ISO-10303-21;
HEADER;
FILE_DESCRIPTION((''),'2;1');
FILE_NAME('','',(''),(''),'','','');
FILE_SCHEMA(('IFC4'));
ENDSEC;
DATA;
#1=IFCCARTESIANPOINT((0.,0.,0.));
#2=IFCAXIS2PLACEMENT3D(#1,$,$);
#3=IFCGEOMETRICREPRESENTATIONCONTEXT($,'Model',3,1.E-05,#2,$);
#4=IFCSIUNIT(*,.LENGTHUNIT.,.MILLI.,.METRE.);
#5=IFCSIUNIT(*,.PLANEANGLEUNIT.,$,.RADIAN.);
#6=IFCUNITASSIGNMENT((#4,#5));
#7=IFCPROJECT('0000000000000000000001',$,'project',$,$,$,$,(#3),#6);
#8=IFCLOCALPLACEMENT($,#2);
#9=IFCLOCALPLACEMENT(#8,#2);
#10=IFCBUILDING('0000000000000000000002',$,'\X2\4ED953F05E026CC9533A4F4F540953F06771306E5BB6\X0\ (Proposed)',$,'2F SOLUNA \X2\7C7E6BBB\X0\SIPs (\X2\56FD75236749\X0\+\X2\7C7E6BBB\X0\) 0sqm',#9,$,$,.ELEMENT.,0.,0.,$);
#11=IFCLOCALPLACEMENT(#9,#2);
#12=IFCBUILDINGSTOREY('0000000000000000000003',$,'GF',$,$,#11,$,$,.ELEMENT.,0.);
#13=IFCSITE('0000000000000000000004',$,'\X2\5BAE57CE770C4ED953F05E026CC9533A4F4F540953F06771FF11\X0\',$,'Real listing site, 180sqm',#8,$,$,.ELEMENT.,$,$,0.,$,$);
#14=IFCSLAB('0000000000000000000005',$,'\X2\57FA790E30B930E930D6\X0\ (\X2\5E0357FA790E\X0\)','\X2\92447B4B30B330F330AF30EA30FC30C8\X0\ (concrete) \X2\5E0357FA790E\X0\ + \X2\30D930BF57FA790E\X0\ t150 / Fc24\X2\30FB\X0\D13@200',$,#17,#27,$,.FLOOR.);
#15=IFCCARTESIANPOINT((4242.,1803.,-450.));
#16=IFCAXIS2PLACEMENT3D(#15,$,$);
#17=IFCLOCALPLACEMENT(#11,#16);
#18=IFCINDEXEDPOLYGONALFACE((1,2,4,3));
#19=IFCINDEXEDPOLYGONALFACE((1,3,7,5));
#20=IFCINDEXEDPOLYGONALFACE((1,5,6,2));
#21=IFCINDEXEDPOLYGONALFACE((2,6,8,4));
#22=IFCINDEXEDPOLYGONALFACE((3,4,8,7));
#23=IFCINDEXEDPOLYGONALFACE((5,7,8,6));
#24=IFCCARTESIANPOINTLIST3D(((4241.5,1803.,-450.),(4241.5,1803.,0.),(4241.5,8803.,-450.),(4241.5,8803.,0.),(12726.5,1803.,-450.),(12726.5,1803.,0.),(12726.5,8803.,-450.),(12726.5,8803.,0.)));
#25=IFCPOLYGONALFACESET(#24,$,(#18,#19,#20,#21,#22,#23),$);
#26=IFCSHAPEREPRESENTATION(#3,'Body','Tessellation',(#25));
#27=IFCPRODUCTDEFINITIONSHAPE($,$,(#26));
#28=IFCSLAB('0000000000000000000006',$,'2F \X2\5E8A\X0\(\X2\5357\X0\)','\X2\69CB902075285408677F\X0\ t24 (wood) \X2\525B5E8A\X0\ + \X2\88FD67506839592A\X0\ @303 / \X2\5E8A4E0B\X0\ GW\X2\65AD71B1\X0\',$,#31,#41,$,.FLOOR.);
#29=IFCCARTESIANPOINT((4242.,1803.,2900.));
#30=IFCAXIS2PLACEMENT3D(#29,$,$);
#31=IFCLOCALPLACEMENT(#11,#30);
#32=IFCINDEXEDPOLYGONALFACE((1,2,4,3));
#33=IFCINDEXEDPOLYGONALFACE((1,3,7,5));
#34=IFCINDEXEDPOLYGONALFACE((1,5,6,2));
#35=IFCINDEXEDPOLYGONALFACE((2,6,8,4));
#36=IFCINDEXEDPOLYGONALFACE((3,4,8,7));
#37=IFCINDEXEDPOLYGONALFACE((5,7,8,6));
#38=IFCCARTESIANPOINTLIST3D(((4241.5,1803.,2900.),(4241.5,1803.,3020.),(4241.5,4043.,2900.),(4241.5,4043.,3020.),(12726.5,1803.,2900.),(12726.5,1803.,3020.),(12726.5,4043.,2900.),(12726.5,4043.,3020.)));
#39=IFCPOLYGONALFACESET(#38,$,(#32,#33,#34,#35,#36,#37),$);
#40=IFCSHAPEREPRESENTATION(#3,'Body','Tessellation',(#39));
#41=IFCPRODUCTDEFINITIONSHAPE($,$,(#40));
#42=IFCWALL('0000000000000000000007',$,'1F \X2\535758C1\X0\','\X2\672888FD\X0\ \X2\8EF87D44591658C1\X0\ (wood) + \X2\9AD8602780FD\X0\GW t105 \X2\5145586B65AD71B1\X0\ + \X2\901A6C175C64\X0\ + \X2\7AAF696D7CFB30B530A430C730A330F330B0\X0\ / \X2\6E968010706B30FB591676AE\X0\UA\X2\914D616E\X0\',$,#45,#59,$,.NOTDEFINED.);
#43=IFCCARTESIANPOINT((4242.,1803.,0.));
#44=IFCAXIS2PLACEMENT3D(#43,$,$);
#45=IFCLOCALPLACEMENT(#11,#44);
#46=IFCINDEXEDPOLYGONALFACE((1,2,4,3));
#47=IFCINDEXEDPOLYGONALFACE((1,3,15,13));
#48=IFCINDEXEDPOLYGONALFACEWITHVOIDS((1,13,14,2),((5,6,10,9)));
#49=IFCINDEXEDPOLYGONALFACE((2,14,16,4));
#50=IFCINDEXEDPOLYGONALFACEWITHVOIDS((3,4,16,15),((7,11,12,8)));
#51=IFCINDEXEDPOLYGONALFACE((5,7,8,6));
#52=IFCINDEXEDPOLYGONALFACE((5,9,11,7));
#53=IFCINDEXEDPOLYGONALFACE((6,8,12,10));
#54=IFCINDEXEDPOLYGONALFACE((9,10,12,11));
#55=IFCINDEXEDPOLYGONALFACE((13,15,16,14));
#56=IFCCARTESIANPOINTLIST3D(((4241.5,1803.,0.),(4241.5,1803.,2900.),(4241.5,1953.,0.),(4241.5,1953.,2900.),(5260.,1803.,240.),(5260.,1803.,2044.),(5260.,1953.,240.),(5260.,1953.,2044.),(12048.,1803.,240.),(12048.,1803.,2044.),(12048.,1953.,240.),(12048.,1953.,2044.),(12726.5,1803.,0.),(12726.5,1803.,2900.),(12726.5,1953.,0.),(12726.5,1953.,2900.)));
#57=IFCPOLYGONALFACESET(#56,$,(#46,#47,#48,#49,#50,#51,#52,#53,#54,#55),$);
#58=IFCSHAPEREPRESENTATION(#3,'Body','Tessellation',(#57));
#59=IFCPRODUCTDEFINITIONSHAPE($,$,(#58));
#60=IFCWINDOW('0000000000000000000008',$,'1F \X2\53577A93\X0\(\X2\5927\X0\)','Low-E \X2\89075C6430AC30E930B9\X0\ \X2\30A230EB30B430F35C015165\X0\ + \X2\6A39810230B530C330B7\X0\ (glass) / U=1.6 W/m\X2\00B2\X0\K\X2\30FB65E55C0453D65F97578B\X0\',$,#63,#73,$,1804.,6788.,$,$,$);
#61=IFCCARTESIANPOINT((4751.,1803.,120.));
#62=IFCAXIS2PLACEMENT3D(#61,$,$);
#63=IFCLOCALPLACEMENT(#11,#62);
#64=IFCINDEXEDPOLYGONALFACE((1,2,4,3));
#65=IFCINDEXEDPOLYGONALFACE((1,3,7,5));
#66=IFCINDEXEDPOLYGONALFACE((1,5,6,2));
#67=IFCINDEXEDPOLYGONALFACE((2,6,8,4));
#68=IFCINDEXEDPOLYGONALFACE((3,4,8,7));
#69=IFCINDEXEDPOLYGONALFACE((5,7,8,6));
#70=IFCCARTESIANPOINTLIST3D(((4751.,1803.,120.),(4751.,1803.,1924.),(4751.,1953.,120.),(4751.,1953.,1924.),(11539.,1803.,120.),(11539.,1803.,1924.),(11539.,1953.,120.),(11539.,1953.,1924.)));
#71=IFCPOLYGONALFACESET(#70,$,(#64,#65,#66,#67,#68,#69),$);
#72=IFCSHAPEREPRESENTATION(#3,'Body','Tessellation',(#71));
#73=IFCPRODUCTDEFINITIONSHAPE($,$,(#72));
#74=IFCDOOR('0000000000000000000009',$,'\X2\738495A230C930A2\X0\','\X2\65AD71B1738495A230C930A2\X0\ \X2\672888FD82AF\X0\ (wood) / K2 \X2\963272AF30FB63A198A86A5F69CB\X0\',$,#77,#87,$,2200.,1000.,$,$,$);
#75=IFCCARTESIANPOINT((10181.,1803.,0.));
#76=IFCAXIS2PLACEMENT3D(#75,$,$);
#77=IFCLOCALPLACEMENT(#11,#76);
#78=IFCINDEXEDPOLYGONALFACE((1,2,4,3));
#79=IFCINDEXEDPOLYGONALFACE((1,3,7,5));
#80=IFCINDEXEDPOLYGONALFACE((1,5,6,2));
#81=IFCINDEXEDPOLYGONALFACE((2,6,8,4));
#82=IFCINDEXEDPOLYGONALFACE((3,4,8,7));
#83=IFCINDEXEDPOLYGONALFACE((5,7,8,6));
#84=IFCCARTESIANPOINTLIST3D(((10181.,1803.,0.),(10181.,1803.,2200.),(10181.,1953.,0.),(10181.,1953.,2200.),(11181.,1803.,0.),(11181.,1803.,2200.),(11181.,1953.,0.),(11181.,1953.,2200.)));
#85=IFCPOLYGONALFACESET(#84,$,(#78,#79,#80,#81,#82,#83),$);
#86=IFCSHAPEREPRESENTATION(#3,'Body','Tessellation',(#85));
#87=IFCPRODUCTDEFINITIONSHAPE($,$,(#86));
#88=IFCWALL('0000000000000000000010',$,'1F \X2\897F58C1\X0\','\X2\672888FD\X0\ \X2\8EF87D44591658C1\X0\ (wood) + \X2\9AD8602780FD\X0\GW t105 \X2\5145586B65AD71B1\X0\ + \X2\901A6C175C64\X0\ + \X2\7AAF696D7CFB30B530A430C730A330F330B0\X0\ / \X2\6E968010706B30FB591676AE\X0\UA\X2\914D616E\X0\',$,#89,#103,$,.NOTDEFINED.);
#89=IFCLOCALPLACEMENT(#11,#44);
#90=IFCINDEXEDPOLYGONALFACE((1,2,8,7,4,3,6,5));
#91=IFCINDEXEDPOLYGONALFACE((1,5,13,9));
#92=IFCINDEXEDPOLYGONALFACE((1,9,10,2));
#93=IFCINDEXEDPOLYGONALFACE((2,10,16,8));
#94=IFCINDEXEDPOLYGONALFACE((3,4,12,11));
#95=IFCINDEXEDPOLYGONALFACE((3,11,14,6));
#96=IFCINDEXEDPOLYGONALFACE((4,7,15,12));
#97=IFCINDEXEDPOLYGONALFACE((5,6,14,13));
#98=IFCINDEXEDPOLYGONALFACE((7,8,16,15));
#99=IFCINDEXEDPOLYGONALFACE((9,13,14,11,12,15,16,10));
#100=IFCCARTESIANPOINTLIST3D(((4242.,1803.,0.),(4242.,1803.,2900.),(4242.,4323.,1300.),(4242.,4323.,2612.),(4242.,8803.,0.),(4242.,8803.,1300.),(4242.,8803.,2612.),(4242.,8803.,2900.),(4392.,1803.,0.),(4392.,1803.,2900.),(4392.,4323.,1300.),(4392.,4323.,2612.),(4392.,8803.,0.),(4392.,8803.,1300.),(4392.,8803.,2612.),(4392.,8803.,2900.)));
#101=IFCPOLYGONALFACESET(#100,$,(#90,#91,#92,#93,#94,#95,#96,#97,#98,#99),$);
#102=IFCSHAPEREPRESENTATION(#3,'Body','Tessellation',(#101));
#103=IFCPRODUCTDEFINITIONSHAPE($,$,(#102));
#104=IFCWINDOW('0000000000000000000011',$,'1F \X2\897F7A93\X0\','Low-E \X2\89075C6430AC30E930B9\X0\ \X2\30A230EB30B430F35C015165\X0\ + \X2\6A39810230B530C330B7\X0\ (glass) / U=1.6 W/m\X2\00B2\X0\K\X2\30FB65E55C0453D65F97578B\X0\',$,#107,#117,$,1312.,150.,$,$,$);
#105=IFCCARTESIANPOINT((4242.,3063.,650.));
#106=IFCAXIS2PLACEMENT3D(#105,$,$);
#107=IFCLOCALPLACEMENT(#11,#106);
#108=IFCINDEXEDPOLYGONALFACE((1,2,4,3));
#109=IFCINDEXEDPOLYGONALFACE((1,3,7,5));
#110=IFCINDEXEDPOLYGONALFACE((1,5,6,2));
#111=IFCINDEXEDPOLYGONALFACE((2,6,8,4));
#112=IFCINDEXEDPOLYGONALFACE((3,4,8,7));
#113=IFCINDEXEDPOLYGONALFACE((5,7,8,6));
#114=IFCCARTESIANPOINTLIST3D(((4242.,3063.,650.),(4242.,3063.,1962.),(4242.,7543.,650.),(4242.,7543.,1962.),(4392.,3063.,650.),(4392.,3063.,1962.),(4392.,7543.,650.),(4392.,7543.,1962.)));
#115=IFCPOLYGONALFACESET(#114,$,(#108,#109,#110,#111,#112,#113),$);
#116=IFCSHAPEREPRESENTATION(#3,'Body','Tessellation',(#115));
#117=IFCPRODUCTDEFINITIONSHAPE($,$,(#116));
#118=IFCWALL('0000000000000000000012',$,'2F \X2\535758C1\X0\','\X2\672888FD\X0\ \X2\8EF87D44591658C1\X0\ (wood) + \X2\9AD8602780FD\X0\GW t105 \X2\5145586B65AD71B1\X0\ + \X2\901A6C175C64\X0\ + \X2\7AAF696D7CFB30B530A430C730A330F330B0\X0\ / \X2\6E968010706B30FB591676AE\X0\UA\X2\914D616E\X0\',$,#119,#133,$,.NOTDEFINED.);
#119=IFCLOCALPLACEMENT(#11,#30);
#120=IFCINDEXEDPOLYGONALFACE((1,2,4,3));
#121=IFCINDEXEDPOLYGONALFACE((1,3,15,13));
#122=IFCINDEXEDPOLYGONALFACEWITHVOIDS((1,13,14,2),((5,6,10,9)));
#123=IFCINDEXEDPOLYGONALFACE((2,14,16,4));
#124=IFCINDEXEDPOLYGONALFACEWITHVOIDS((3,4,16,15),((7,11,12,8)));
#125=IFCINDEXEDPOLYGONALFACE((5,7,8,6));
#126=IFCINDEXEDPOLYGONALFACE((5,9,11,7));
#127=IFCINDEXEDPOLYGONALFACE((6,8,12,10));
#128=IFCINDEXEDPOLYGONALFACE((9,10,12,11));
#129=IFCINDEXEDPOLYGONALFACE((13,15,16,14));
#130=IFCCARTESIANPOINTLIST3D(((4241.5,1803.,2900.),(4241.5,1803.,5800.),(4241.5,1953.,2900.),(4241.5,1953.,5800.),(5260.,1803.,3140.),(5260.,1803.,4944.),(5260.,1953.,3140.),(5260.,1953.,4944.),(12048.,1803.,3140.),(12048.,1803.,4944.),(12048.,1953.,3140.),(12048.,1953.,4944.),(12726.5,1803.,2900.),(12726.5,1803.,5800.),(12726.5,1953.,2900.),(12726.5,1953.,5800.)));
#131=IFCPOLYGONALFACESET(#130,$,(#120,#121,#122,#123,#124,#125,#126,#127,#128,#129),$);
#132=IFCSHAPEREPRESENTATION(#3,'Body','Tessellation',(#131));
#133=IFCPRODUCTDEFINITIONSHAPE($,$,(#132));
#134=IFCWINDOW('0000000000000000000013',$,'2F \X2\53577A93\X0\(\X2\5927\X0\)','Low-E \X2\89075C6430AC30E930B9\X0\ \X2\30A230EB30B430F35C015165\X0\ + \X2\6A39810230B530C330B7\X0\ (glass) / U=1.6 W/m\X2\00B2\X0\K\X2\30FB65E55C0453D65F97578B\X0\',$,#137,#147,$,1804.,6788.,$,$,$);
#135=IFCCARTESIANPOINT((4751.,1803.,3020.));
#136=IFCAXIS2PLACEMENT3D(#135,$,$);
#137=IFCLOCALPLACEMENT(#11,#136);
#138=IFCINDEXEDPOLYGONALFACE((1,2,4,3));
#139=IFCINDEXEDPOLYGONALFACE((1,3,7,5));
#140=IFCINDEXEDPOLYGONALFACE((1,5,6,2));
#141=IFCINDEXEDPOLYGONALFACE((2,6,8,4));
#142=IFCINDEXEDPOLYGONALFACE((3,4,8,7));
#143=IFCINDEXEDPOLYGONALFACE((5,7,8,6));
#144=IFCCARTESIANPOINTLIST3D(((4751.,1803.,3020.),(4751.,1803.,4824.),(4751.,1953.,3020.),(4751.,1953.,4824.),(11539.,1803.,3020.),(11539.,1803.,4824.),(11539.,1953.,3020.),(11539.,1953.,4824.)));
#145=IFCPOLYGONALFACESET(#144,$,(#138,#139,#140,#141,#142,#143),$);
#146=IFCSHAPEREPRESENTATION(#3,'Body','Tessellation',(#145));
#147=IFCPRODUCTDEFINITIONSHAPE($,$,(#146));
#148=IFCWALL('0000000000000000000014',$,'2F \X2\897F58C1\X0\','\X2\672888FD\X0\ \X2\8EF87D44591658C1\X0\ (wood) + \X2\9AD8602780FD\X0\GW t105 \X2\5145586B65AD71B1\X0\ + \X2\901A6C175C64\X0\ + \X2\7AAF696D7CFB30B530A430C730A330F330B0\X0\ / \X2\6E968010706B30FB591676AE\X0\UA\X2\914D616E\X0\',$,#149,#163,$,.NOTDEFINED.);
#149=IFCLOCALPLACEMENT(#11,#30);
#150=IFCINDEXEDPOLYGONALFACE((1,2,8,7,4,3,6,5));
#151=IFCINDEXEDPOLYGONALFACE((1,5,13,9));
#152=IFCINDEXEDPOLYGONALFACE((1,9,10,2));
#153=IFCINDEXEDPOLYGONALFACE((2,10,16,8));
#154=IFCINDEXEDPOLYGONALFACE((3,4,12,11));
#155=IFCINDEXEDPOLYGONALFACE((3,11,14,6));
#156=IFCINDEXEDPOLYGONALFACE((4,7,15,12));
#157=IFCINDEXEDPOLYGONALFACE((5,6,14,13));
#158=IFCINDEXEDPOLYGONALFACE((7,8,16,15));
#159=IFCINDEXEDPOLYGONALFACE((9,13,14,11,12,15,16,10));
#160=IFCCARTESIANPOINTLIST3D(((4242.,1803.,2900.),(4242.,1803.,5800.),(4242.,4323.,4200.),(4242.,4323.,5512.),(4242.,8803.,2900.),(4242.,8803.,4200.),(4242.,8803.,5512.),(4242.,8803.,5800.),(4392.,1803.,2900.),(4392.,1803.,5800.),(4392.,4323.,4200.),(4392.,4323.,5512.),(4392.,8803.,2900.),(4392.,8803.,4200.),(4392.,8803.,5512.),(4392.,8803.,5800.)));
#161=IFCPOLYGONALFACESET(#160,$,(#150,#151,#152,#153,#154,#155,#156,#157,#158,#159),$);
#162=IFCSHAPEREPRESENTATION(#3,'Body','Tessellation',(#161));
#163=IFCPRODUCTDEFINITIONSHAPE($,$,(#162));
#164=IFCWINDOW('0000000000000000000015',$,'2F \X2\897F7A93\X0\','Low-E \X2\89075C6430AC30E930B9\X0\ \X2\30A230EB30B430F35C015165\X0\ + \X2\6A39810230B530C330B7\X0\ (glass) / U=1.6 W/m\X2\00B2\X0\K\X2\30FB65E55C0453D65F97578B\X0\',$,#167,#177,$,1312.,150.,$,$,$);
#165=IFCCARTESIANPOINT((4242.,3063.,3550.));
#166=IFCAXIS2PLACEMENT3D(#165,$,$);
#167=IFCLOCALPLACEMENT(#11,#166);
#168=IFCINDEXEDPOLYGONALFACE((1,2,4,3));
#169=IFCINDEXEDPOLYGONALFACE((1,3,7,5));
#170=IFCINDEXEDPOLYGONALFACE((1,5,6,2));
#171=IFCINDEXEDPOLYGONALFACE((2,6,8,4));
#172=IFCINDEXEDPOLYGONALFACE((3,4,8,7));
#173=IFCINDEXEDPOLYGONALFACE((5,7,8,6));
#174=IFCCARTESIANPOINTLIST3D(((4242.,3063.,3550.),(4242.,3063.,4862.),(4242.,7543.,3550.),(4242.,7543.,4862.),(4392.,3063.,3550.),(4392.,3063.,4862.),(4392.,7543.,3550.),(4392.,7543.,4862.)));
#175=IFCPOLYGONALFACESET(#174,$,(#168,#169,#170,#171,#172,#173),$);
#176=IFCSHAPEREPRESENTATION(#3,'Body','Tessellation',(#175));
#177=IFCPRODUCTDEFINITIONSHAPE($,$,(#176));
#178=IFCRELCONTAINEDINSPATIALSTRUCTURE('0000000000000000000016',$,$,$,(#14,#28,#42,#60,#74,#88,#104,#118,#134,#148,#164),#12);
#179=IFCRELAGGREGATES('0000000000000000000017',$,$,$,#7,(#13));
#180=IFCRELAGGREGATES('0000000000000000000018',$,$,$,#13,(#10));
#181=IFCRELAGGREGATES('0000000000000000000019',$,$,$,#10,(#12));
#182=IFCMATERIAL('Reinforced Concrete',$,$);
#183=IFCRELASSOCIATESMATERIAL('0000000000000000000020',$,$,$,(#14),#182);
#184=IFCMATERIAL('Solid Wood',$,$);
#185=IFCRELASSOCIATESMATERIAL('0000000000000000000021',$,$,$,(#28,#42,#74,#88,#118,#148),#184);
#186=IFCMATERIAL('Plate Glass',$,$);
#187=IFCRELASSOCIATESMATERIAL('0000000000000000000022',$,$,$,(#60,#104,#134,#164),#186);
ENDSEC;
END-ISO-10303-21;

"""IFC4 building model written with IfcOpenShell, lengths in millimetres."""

from ifc_helpers import new_model, si_unit, frame, frame_2d, origin, place, context, project, spatial, rectangle, extrude, material, element, fill, save


model = new_model("IFC4")

# Units and contexts
model_context = context("Model", 3, precision=1e-05, world=origin())
ifc_project = project(units=[si_unit("LENGTHUNIT", "METRE", prefix="MILLI"), si_unit("PLANEANGLEUNIT", "RADIAN")], contexts=[model_context])

# Site, building, storey
site_placement = place(None, origin())
site = spatial("IfcSite", under=ifc_project, at=site_placement, Name="宮城県仙台市泉区住吉台東１", ObjectType="Real listing site, 180sqm", CompositionType="ELEMENT", RefElevation=0.0)
building_placement = place(site_placement, origin())
building = spatial("IfcBuilding", under=site, at=building_placement, Name="仙台市泉区住吉台東の家 (Proposed)", ObjectType="2F SOLUNA 籾殻SIPs (国産杉+籾殻) 0sqm", CompositionType="ELEMENT", ElevationOfRefHeight=0.0, ElevationOfTerrain=0.0)
storey_placement = place(building_placement, origin())
storey = spatial("IfcBuildingStorey", under=building, at=storey_placement, Name="GF", CompositionType="ELEMENT", Elevation=0.0)

# Slabs
ifc_material_1 = material(Name="Reinforced Concrete")
slab_1_placement = place(storey_placement, frame((4242.0, 1803.0, -450.0)))
element("IfcSlab", 1, at=slab_1_placement, inside=storey, material=ifc_material_1, Name="基礎スラブ (布基礎)", Description="鉄筋コンクリート (concrete) 布基礎 + ベタ基礎 t150 / Fc24・D13@200", PredefinedType="FLOOR", context=model_context, shape_type="SweptSolid", body=[
    extrude(rectangle(XDim=8485.0, YDim=7000.0, at=frame_2d((4242.0, 3500.0))), frame((4242.0, 1803.0, -450.0)), (0.0, 0.0, 1.0), 450.0),
])
ifc_material_2 = material(Name="Solid Wood")
slab_2_placement = place(storey_placement, frame((4242.0, 1803.0, 2900.0)))
element("IfcSlab", 2, at=slab_2_placement, inside=storey, material=ifc_material_2, Name="2F 床(南)", Description="構造用合板 t24 (wood) 剛床 + 製材根太 @303 / 床下 GW断熱", PredefinedType="FLOOR", context=model_context, shape_type="SweptSolid", body=[
    extrude(rectangle(XDim=8485.0, YDim=2240.0, at=frame_2d((4242.0, 1120.0))), frame((4242.0, 1803.0, 2900.0)), (0.0, 0.0, 1.0), 120.0),
])

# Wall, openings, window, door
wall_1_placement = place(storey_placement, frame((4242.0, 1803.0, 0.0)))
wall_1 = element("IfcWall", 3, at=wall_1_placement, inside=storey, material=ifc_material_2, Name="1F 南壁", Description="木製 軸組外壁 (wood) + 高性能GW t105 充填断熱 + 通気層 + 窯業系サイディング / 準耐火・外皮UA配慮", PredefinedType="NOTDEFINED", context=model_context, shape_type="SweptSolid", body=[
    extrude(rectangle(XDim=8485.0, YDim=150.0, at=frame_2d((4242.0, 75.0))), frame((4242.0, 1803.0, 0.0)), (0.0, 0.0, 1.0), 2900.0),
])
opening_1_placement = place(storey_placement, frame((4751.0, 1803.0, 120.0)))
opening_1 = element("IfcOpeningElement", 4, at=opening_1_placement, cuts=wall_1, PredefinedType="NOTDEFINED", context=model_context, shape_type="SweptSolid", body=[
    extrude(rectangle(XDim=6788.0, YDim=150.0, at=frame_2d((3394.0, 75.0))), frame((4751.0, 1803.0, 120.0)), (0.0, 0.0, 1.0), 1804.0),
])
opening_2_placement = place(storey_placement, frame((10181.0, 1803.0, 0.0)))
opening_2 = element("IfcOpeningElement", 5, at=opening_2_placement, cuts=wall_1, PredefinedType="NOTDEFINED", context=model_context, shape_type="SweptSolid", body=[
    extrude(rectangle(XDim=1000.0, YDim=150.0, at=frame_2d((500.0, 75.0))), frame((10181.0, 1803.0, 0.0)), (0.0, 0.0, 1.0), 2200.0),
])
ifc_material_3 = material(Name="Plate Glass")
window_1_placement = place(storey_placement, frame((4751.0, 1803.0, 120.0)))
window_1 = element("IfcWindow", 6, at=window_1_placement, inside=storey, material=ifc_material_3, Name="1F 南窓(大)", Description="Low-E 複層ガラス アルゴン封入 + 樹脂サッシ (glass) / U=1.6 W/m²K・日射取得型", OverallHeight=1804.0, OverallWidth=6788.0, context=model_context, shape_type="SweptSolid", body=[
    extrude(rectangle(XDim=6788.0, YDim=150.0, at=frame_2d((3394.0, 75.0))), frame((4751.0, 1803.0, 120.0)), (0.0, 0.0, 1.0), 1804.0),
])
fill(opening_1, window_1)
door_placement = place(storey_placement, frame((10181.0, 1803.0, 0.0)))
door = element("IfcDoor", 7, at=door_placement, inside=storey, material=ifc_material_2, Name="玄関ドア", Description="断熱玄関ドア 木製芯 (wood) / K2 防犯・採風機構", OverallHeight=2200.0, OverallWidth=1000.0, context=model_context, shape_type="SweptSolid", body=[
    extrude(rectangle(XDim=1000.0, YDim=150.0, at=frame_2d((500.0, 75.0))), frame((10181.0, 1803.0, 0.0)), (0.0, 0.0, 1.0), 2200.0),
])
fill(opening_2, door)

# Walls, openings, windows
wall_2_placement = place(storey_placement, frame((4242.0, 1803.0, 0.0)))
wall_2 = element("IfcWall", 8, at=wall_2_placement, inside=storey, material=ifc_material_2, Name="1F 西壁", Description="木製 軸組外壁 (wood) + 高性能GW t105 充填断熱 + 通気層 + 窯業系サイディング / 準耐火・外皮UA配慮", PredefinedType="NOTDEFINED", context=model_context, shape_type="SweptSolid", body=[
    extrude(rectangle(XDim=150.0, YDim=7000.0, at=frame_2d((75.0, 3500.0))), frame((4242.0, 1803.0, 0.0)), (0.0, 0.0, 1.0), 2900.0),
])
opening_3_placement = place(storey_placement, frame((4242.0, 3063.0, 650.0)))
opening_3 = element("IfcOpeningElement", 9, at=opening_3_placement, cuts=wall_2, PredefinedType="NOTDEFINED", context=model_context, shape_type="SweptSolid", body=[
    extrude(rectangle(XDim=150.0, YDim=4480.0, at=frame_2d((75.0, 2240.0))), frame((4242.0, 3063.0, 650.0)), (0.0, 0.0, 1.0), 1312.0),
])
window_2_placement = place(storey_placement, frame((4242.0, 3063.0, 650.0)))
window_2 = element("IfcWindow", 10, at=window_2_placement, inside=storey, material=ifc_material_3, Name="1F 西窓", Description="Low-E 複層ガラス アルゴン封入 + 樹脂サッシ (glass) / U=1.6 W/m²K・日射取得型", OverallHeight=1312.0, OverallWidth=150.0, context=model_context, shape_type="SweptSolid", body=[
    extrude(rectangle(XDim=150.0, YDim=4480.0, at=frame_2d((75.0, 2240.0))), frame((4242.0, 3063.0, 650.0)), (0.0, 0.0, 1.0), 1312.0),
])
fill(opening_3, window_2)
wall_3_placement = place(storey_placement, frame((4242.0, 1803.0, 2900.0)))
wall_3 = element("IfcWall", 11, at=wall_3_placement, inside=storey, material=ifc_material_2, Name="2F 南壁", Description="木製 軸組外壁 (wood) + 高性能GW t105 充填断熱 + 通気層 + 窯業系サイディング / 準耐火・外皮UA配慮", PredefinedType="NOTDEFINED", context=model_context, shape_type="SweptSolid", body=[
    extrude(rectangle(XDim=8485.0, YDim=150.0, at=frame_2d((4242.0, 75.0))), frame((4242.0, 1803.0, 2900.0)), (0.0, 0.0, 1.0), 2900.0),
])
opening_4_placement = place(storey_placement, frame((4751.0, 1803.0, 3020.0)))
opening_4 = element("IfcOpeningElement", 12, at=opening_4_placement, cuts=wall_3, PredefinedType="NOTDEFINED", context=model_context, shape_type="SweptSolid", body=[
    extrude(rectangle(XDim=6788.0, YDim=150.0, at=frame_2d((3394.0, 75.0))), frame((4751.0, 1803.0, 3020.0)), (0.0, 0.0, 1.0), 1804.0),
])
window_3_placement = place(storey_placement, frame((4751.0, 1803.0, 3020.0)))
window_3 = element("IfcWindow", 13, at=window_3_placement, inside=storey, material=ifc_material_3, Name="2F 南窓(大)", Description="Low-E 複層ガラス アルゴン封入 + 樹脂サッシ (glass) / U=1.6 W/m²K・日射取得型", OverallHeight=1804.0, OverallWidth=6788.0, context=model_context, shape_type="SweptSolid", body=[
    extrude(rectangle(XDim=6788.0, YDim=150.0, at=frame_2d((3394.0, 75.0))), frame((4751.0, 1803.0, 3020.0)), (0.0, 0.0, 1.0), 1804.0),
])
fill(opening_4, window_3)
wall_4_placement = place(storey_placement, frame((4242.0, 1803.0, 2900.0)))
wall_4 = element("IfcWall", 14, at=wall_4_placement, inside=storey, material=ifc_material_2, Name="2F 西壁", Description="木製 軸組外壁 (wood) + 高性能GW t105 充填断熱 + 通気層 + 窯業系サイディング / 準耐火・外皮UA配慮", PredefinedType="NOTDEFINED", context=model_context, shape_type="SweptSolid", body=[
    extrude(rectangle(XDim=150.0, YDim=7000.0, at=frame_2d((75.0, 3500.0))), frame((4242.0, 1803.0, 2900.0)), (0.0, 0.0, 1.0), 2900.0),
])
opening_5_placement = place(storey_placement, frame((4242.0, 3063.0, 3550.0)))
opening_5 = element("IfcOpeningElement", 15, at=opening_5_placement, cuts=wall_4, PredefinedType="NOTDEFINED", context=model_context, shape_type="SweptSolid", body=[
    extrude(rectangle(XDim=150.0, YDim=4480.0, at=frame_2d((75.0, 2240.0))), frame((4242.0, 3063.0, 3550.0)), (0.0, 0.0, 1.0), 1312.0),
])
window_4_placement = place(storey_placement, frame((4242.0, 3063.0, 3550.0)))
window_4 = element("IfcWindow", 16, at=window_4_placement, inside=storey, material=ifc_material_3, Name="2F 西窓", Description="Low-E 複層ガラス アルゴン封入 + 樹脂サッシ (glass) / U=1.6 W/m²K・日射取得型", OverallHeight=1312.0, OverallWidth=150.0, context=model_context, shape_type="SweptSolid", body=[
    extrude(rectangle(XDim=150.0, YDim=4480.0, at=frame_2d((75.0, 2240.0))), frame((4242.0, 3063.0, 3550.0)), (0.0, 0.0, 1.0), 1312.0),
])
fill(opening_5, window_4)

save(model, "model.ifc")
